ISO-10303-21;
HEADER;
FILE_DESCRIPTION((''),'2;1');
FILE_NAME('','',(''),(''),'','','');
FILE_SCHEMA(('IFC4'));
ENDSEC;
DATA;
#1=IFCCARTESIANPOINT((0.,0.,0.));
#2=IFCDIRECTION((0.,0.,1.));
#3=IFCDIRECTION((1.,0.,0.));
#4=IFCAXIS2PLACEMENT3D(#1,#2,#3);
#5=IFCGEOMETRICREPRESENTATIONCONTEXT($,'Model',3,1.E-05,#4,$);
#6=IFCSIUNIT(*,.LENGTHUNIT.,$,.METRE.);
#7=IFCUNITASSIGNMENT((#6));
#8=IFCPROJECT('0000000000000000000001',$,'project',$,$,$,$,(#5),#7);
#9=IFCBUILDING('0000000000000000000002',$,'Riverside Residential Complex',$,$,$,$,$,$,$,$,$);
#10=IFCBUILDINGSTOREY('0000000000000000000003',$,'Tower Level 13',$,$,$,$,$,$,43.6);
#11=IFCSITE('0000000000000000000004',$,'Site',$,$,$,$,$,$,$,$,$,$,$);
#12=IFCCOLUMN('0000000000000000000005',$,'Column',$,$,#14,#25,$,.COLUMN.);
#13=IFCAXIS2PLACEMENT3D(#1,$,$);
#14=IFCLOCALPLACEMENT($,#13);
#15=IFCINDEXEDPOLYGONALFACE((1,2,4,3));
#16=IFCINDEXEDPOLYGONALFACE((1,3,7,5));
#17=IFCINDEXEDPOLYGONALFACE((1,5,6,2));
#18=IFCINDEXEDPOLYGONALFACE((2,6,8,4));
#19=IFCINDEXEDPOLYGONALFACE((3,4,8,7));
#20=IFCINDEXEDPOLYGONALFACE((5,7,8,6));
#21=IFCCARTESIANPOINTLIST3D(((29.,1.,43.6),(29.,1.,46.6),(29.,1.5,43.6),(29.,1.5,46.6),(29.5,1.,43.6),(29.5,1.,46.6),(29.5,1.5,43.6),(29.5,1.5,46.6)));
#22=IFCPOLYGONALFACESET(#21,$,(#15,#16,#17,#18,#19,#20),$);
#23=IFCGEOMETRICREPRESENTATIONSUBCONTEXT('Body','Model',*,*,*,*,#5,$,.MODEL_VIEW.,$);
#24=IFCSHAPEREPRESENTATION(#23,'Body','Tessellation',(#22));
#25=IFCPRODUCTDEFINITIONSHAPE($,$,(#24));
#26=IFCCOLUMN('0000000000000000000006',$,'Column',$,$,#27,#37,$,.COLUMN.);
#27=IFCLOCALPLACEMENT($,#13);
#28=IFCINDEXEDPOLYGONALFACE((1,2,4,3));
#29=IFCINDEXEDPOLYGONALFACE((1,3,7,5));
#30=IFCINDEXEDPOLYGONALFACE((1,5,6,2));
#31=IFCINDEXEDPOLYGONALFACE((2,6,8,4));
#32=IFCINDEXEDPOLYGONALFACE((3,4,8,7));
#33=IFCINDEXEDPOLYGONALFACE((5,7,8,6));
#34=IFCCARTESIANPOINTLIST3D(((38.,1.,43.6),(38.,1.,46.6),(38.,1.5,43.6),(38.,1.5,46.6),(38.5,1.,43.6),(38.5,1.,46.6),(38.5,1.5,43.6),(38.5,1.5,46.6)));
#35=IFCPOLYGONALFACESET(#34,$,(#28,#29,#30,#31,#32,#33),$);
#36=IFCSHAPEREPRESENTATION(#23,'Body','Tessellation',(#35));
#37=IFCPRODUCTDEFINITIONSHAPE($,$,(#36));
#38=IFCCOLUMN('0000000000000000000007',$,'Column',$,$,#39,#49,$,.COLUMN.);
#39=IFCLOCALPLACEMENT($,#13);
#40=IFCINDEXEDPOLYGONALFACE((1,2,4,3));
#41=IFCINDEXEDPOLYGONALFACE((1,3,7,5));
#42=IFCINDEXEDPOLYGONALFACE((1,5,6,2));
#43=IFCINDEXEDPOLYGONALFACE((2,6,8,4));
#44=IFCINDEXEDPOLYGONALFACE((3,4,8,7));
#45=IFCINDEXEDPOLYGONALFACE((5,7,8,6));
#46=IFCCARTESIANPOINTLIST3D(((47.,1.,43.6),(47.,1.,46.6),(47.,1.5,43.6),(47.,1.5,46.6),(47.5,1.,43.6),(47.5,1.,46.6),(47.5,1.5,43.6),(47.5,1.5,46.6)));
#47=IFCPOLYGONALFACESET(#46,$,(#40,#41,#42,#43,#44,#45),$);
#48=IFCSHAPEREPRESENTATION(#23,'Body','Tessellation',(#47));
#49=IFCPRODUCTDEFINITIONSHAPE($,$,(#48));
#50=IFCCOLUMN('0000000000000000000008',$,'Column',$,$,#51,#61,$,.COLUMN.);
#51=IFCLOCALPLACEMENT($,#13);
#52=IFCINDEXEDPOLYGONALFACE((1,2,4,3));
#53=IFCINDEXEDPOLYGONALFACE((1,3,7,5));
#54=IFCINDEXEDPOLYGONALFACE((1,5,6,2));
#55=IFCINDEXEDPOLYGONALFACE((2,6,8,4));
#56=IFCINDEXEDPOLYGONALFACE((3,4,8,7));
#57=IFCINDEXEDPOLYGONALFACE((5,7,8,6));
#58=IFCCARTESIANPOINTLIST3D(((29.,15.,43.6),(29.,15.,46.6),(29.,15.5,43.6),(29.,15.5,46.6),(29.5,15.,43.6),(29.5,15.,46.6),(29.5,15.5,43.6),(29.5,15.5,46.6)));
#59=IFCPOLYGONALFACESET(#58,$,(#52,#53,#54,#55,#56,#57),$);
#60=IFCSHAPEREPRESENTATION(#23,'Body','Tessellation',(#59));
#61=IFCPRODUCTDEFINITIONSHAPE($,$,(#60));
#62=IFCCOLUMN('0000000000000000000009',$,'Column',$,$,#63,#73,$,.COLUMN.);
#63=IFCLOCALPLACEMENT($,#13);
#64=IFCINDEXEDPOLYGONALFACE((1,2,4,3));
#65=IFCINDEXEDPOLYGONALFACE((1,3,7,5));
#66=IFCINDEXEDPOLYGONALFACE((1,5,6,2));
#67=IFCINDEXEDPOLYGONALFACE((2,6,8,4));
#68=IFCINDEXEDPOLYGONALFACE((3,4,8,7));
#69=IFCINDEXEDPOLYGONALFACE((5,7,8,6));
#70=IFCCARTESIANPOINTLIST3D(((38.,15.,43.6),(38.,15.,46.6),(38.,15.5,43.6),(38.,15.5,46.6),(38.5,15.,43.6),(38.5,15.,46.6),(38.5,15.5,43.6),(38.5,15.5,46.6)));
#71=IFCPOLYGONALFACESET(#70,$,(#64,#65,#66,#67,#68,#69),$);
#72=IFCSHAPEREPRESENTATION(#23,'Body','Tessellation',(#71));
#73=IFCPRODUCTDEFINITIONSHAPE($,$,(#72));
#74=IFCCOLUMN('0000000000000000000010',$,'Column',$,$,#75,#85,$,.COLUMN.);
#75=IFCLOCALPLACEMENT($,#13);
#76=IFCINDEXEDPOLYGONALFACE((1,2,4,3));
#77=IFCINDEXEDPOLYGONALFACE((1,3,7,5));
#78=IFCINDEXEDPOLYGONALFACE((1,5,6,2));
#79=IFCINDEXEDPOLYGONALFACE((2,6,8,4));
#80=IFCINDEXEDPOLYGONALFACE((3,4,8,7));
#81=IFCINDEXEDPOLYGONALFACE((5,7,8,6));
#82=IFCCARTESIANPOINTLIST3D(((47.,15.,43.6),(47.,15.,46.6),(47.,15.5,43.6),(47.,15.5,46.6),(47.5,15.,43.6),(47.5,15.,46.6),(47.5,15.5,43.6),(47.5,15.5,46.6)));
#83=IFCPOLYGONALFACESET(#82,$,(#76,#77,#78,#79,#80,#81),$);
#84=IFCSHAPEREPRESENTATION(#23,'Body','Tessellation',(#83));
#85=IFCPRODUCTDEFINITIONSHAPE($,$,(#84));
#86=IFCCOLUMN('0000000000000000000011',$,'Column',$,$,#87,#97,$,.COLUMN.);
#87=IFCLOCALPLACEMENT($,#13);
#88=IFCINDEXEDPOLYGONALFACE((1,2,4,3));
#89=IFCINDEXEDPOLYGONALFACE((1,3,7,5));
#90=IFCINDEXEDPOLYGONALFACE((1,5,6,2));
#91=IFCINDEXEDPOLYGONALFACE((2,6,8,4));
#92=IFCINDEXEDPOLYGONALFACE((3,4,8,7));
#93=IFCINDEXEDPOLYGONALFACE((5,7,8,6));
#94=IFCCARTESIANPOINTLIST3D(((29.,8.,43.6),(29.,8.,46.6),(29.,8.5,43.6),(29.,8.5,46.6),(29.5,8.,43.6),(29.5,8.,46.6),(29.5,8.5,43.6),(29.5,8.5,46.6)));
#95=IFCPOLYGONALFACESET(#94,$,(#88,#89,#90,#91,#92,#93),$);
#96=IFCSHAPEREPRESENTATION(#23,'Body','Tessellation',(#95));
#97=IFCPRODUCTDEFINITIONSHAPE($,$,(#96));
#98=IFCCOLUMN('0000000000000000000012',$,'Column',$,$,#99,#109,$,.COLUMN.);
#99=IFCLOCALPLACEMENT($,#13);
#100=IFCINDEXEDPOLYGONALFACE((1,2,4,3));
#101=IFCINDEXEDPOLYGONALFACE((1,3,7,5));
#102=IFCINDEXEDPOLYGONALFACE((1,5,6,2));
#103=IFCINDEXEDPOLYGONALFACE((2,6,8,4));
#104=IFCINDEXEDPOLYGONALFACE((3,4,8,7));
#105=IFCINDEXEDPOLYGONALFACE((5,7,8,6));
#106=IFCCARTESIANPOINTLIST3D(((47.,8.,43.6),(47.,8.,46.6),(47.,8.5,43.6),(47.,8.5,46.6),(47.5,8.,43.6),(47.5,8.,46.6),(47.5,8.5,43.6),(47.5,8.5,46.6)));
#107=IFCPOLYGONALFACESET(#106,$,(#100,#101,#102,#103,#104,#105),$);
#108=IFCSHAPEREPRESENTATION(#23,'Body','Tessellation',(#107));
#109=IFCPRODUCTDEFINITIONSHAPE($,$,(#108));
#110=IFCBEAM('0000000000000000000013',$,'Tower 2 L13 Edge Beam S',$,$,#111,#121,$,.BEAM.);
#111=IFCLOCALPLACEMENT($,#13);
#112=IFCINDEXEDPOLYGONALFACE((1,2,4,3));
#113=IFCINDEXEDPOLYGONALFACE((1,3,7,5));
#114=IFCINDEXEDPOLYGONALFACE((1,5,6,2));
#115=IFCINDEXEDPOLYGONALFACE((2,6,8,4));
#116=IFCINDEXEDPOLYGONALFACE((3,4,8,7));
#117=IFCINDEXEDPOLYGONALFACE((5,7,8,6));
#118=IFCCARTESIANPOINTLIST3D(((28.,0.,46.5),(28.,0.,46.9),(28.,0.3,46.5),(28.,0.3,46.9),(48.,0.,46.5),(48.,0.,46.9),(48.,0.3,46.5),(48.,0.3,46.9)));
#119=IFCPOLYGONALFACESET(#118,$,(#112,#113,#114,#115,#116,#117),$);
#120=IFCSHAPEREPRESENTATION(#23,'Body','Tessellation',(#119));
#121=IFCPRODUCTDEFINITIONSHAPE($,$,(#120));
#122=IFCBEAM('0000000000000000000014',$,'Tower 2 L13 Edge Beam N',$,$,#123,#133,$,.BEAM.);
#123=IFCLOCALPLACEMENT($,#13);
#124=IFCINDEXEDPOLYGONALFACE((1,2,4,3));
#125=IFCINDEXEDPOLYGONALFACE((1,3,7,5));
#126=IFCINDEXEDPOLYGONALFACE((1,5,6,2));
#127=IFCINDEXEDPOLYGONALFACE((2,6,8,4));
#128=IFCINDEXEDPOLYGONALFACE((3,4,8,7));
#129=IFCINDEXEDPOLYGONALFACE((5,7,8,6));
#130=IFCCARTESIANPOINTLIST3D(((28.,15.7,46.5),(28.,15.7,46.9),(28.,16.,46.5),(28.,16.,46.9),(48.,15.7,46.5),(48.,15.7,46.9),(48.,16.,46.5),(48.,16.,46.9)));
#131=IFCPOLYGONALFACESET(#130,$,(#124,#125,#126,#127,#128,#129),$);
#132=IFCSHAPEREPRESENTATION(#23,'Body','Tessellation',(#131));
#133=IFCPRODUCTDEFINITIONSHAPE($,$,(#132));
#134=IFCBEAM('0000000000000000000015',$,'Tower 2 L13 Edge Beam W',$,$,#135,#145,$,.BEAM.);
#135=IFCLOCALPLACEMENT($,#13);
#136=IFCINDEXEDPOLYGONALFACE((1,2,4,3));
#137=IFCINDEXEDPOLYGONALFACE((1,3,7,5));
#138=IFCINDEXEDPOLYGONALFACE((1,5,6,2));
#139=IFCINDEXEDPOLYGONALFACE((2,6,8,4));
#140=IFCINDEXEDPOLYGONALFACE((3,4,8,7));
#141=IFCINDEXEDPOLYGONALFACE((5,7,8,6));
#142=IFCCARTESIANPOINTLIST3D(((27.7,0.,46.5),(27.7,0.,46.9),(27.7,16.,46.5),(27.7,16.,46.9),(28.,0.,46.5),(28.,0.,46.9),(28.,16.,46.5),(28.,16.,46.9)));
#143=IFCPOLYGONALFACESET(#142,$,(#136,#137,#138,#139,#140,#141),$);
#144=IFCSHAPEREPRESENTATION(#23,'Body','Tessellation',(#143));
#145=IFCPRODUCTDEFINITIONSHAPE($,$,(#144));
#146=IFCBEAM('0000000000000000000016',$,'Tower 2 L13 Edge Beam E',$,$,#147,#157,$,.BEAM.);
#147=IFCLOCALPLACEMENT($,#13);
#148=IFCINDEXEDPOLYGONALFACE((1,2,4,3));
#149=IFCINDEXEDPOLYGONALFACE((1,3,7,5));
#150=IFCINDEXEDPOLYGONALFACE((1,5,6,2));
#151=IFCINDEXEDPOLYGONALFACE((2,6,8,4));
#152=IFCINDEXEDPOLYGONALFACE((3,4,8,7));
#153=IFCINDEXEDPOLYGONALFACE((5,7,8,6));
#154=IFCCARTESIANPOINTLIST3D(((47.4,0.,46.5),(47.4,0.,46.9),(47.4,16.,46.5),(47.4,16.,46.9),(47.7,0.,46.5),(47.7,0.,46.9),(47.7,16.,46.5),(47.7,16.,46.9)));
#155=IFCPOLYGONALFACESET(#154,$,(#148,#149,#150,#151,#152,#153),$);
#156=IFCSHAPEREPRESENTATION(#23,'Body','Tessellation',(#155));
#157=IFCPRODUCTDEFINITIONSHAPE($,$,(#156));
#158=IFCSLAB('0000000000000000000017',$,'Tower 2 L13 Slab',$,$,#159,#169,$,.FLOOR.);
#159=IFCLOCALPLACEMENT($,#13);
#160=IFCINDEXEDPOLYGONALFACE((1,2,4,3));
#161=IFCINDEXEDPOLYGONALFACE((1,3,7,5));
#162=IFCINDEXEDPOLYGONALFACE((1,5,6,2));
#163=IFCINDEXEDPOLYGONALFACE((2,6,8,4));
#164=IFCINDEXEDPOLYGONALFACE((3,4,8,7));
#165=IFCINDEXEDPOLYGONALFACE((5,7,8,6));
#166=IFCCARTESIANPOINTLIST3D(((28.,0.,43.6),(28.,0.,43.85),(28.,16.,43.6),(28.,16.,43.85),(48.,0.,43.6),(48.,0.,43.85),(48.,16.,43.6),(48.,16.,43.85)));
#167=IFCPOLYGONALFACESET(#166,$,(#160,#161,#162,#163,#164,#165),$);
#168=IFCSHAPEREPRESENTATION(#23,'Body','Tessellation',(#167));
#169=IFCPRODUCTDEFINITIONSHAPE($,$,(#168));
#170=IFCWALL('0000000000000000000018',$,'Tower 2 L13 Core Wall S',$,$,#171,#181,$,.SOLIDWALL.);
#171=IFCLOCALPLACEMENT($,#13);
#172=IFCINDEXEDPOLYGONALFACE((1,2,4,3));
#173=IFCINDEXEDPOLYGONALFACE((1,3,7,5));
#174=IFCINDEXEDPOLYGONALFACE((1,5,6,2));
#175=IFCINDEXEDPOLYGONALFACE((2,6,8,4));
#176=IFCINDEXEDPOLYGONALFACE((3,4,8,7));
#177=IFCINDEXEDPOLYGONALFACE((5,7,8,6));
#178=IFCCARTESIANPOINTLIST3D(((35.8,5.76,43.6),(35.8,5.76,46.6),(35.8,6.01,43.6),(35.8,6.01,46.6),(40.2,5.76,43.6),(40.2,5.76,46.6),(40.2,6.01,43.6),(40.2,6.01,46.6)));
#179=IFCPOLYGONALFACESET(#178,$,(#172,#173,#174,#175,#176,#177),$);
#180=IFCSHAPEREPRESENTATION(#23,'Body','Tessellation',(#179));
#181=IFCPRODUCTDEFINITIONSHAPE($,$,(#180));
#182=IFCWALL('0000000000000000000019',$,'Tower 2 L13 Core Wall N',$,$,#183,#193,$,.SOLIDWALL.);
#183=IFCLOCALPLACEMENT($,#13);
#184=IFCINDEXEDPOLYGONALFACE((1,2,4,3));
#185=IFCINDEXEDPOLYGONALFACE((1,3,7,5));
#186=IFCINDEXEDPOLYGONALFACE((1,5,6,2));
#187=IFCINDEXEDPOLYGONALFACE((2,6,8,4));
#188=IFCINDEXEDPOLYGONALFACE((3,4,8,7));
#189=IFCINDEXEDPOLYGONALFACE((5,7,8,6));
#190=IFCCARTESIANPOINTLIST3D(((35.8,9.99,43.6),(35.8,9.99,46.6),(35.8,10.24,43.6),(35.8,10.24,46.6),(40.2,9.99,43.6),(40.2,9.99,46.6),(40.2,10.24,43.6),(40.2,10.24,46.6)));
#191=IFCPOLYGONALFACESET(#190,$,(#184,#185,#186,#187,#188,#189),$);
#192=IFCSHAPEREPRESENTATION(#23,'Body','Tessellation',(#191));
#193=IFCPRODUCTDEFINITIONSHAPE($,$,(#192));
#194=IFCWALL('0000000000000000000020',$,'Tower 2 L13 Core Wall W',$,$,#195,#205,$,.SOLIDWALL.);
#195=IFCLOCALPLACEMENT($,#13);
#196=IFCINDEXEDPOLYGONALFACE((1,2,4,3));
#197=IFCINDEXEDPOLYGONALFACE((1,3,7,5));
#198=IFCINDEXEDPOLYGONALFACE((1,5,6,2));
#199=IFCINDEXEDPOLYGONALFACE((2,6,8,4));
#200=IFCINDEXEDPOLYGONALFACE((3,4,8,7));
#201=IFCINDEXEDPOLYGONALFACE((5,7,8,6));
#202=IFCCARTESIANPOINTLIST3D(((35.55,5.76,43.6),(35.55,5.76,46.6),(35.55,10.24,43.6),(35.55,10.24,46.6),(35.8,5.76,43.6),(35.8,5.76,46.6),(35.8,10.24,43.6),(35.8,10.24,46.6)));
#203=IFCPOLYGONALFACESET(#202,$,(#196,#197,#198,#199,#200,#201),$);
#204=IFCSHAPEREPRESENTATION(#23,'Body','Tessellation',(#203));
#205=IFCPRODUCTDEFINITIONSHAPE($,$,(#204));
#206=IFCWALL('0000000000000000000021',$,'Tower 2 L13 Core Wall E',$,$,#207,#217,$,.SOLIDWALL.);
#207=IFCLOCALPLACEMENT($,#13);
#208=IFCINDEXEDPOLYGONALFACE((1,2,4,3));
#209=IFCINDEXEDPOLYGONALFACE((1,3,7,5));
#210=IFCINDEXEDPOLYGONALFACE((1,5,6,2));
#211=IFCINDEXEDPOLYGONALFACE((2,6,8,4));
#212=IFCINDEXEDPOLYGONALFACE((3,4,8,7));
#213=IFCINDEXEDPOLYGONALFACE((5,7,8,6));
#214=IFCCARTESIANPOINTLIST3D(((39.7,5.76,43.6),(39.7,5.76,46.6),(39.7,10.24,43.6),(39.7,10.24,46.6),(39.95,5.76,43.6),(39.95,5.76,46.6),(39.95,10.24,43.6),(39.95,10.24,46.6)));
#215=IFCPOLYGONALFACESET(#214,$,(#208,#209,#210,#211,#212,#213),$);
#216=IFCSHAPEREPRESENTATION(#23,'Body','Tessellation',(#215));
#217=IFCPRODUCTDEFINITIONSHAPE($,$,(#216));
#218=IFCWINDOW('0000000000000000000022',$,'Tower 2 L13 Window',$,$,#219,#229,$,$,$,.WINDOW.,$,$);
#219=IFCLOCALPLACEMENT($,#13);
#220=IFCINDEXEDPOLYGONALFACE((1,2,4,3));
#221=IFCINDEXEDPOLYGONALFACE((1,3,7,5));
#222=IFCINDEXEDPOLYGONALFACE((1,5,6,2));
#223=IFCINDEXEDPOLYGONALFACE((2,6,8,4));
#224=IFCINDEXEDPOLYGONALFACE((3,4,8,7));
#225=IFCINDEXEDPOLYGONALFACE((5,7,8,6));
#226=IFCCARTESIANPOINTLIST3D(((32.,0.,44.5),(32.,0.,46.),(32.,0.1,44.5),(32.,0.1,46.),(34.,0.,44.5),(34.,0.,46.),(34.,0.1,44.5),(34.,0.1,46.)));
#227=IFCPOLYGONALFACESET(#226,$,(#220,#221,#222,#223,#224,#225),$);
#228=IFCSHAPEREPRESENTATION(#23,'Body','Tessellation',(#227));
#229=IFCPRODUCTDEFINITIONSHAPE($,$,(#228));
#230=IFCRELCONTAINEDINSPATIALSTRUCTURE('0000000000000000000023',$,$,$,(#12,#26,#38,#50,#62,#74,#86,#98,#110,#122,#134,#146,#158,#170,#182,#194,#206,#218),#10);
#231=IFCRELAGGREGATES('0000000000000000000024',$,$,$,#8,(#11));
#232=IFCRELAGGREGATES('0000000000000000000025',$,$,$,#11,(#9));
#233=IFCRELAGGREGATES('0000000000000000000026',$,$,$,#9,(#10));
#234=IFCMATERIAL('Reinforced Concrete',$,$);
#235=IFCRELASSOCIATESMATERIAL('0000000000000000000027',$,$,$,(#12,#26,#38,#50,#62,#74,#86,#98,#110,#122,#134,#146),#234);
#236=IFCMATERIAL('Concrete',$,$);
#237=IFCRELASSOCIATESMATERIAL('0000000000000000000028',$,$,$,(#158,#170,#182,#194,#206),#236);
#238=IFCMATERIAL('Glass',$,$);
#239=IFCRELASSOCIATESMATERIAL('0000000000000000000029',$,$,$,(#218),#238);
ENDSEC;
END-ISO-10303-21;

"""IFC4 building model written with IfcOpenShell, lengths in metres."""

from ifc_helpers import new_model, si_unit, frame, origin_with_axes, place, context, subcontext, project, spatial, line, indexed_curve, outline, extrude, material, element, save


model = new_model("IFC4")

# Units and contexts
model_context = context("Model", 3, precision=1e-05, world=origin_with_axes())
body_context = subcontext(model_context, "Body", "Model", "MODEL_VIEW")
ifc_project = project(units=[si_unit("LENGTHUNIT", "METRE")], contexts=[model_context])

# Site, building, storey
site = spatial("IfcSite", under=ifc_project, Name="Site")
building = spatial("IfcBuilding", under=site, Name="Riverside Residential Complex")
storey = spatial("IfcBuildingStorey", under=building, Name="Tower Level 13", Elevation=43.6)

# Columns
ifc_material_1 = material(Name="Reinforced Concrete")
for number, where, z_axis, x_axis, name in (
    (1, (29.0, 1.0, 43.6), (0.0, 0.0, 1.0), (1.0, 0.0, 0.0), "Column"),
    (2, (38.0, 1.0, 43.6), (0.0, 0.0, 1.0), (1.0, 0.0, 0.0), "Column"),
    (3, (47.0, 1.0, 43.6), (0.0, 0.0, 1.0), (1.0, 0.0, 0.0), "Column"),
    (4, (29.0, 15.0, 43.6), (0.0, 0.0, 1.0), (1.0, 0.0, 0.0), "Column"),
    (5, (38.0, 15.0, 43.6), (0.0, 0.0, 1.0), (1.0, 0.0, 0.0), "Column"),
    (6, (47.0, 15.0, 43.6), (0.0, 0.0, 1.0), (1.0, 0.0, 0.0), "Column"),
    (7, (29.0, 8.0, 43.6), (0.0, 0.0, 1.0), (1.0, 0.0, 0.0), "Column"),
    (8, (47.0, 8.0, 43.6), (0.0, 0.0, 1.0), (1.0, 0.0, 0.0), "Column"),
):
    element("IfcColumn", number, at=place(None, frame(where, z_axis=z_axis, x_axis=x_axis)), inside=storey, material=ifc_material_1, Name=name, PredefinedType="COLUMN", context=body_context, shape_type="SweptSolid", body=[
        extrude(outline(indexed_curve([(0.0, 0.0), (0.5, 0.0), (0.5, 0.5), (0.0, 0.5)], segments=[line(1, 2, 3, 4, 1)])), origin_with_axes(), (0.0, 0.0, 1.0), 3.0),
    ])

# Beams
for number, where, z_axis, x_axis, name in (
    (9, (28.0, 0.0, 46.5), (0.0, 0.0, 1.0), (1.0, 0.0, 0.0), "Tower 2 L13 Edge Beam S"),
    (10, (28.0, 15.7, 46.5), (0.0, 0.0, 1.0), (1.0, 0.0, 0.0), "Tower 2 L13 Edge Beam N"),
):
    element("IfcBeam", number, at=place(None, frame(where, z_axis=z_axis, x_axis=x_axis)), inside=storey, material=ifc_material_1, Name=name, PredefinedType="BEAM", context=body_context, shape_type="SweptSolid", body=[
        extrude(outline(indexed_curve([(0.0, 0.0), (20.0, 0.0), (20.0, 0.3), (0.0, 0.3)], segments=[line(1, 2, 3, 4, 1)])), origin_with_axes(), (0.0, 0.0, 1.0), 0.4),
    ])
for number, where, z_axis, x_axis, name in (
    (11, (28.0, 0.0, 46.5), (0.0, 0.0, 1.0), (0.0, 1.0, 0.0), "Tower 2 L13 Edge Beam W"),
    (12, (47.7, 0.0, 46.5), (0.0, 0.0, 1.0), (0.0, 1.0, 0.0), "Tower 2 L13 Edge Beam E"),
):
    element("IfcBeam", number, at=place(None, frame(where, z_axis=z_axis, x_axis=x_axis)), inside=storey, material=ifc_material_1, Name=name, PredefinedType="BEAM", context=body_context, shape_type="SweptSolid", body=[
        extrude(outline(indexed_curve([(0.0, 0.0), (16.0, 0.0), (16.0, 0.3), (0.0, 0.3)], segments=[line(1, 2, 3, 4, 1)])), origin_with_axes(), (0.0, 0.0, 1.0), 0.4),
    ])

# Slab
ifc_material_2 = material(Name="Concrete")
slab_placement = place(None, frame((28.0, 0.0, 43.6), z_axis=(0.0, 0.0, 1.0), x_axis=(1.0, 0.0, 0.0)))
element("IfcSlab", 13, at=slab_placement, inside=storey, material=ifc_material_2, Name="Tower 2 L13 Slab", PredefinedType="FLOOR", context=body_context, shape_type="SweptSolid", body=[
    extrude(outline(indexed_curve([(0.0, 0.0), (20.0, 0.0), (20.0, 16.0), (0.0, 16.0)], segments=[line(1, 2, 3, 4, 1)])), origin_with_axes(), (0.0, 0.0, 1.0), 0.25),
])

# Walls
for number, where, z_axis, x_axis, name in (
    (14, (35.8, 5.76, 43.6), (0.0, 0.0, 1.0), (1.0, 0.0, 0.0), "Tower 2 L13 Core Wall S"),
    (15, (35.8, 9.99, 43.6), (0.0, 0.0, 1.0), (1.0, 0.0, 0.0), "Tower 2 L13 Core Wall N"),
):
    element("IfcWall", number, at=place(None, frame(where, z_axis=z_axis, x_axis=x_axis)), inside=storey, material=ifc_material_2, Name=name, PredefinedType="SOLIDWALL", context=body_context, shape_type="SweptSolid", body=[
        extrude(outline(indexed_curve([(0.0, 0.0), (4.4, 0.0), (4.4, 0.25), (0.0, 0.25)], segments=[line(1, 2, 3, 4, 1)])), origin_with_axes(), (0.0, 0.0, 1.0), 3.0),
    ])
for number, where, z_axis, x_axis, name in (
    (16, (35.8, 5.76, 43.6), (0.0, 0.0, 1.0), (0.0, 1.0, 0.0), "Tower 2 L13 Core Wall W"),
    (17, (39.95, 5.76, 43.6), (0.0, 0.0, 1.0), (0.0, 1.0, 0.0), "Tower 2 L13 Core Wall E"),
):
    element("IfcWall", number, at=place(None, frame(where, z_axis=z_axis, x_axis=x_axis)), inside=storey, material=ifc_material_2, Name=name, PredefinedType="SOLIDWALL", context=body_context, shape_type="SweptSolid", body=[
        extrude(outline(indexed_curve([(0.0, 0.0), (4.48, 0.0), (4.48, 0.25), (0.0, 0.25)], segments=[line(1, 2, 3, 4, 1)])), origin_with_axes(), (0.0, 0.0, 1.0), 3.0),
    ])

# Window
ifc_material_3 = material(Name="Glass")
for number, where, z_axis, x_axis, name in (
    (18, (32.0, 0.0, 44.5), (0.0, 0.0, 1.0), (1.0, 0.0, 0.0), "Tower 2 L13 Window"),
):
    element("IfcWindow", number, at=place(None, frame(where, z_axis=z_axis, x_axis=x_axis)), inside=storey, material=ifc_material_3, Name=name, PredefinedType="WINDOW", context=body_context, shape_type="SweptSolid", body=[
        extrude(outline(indexed_curve([(0.0, 0.0), (2.0, 0.0), (2.0, 0.1), (0.0, 0.1)], segments=[line(1, 2, 3, 4, 1)])), origin_with_axes(), (0.0, 0.0, 1.0), 1.5),
    ])

save(model, "model.ifc")
